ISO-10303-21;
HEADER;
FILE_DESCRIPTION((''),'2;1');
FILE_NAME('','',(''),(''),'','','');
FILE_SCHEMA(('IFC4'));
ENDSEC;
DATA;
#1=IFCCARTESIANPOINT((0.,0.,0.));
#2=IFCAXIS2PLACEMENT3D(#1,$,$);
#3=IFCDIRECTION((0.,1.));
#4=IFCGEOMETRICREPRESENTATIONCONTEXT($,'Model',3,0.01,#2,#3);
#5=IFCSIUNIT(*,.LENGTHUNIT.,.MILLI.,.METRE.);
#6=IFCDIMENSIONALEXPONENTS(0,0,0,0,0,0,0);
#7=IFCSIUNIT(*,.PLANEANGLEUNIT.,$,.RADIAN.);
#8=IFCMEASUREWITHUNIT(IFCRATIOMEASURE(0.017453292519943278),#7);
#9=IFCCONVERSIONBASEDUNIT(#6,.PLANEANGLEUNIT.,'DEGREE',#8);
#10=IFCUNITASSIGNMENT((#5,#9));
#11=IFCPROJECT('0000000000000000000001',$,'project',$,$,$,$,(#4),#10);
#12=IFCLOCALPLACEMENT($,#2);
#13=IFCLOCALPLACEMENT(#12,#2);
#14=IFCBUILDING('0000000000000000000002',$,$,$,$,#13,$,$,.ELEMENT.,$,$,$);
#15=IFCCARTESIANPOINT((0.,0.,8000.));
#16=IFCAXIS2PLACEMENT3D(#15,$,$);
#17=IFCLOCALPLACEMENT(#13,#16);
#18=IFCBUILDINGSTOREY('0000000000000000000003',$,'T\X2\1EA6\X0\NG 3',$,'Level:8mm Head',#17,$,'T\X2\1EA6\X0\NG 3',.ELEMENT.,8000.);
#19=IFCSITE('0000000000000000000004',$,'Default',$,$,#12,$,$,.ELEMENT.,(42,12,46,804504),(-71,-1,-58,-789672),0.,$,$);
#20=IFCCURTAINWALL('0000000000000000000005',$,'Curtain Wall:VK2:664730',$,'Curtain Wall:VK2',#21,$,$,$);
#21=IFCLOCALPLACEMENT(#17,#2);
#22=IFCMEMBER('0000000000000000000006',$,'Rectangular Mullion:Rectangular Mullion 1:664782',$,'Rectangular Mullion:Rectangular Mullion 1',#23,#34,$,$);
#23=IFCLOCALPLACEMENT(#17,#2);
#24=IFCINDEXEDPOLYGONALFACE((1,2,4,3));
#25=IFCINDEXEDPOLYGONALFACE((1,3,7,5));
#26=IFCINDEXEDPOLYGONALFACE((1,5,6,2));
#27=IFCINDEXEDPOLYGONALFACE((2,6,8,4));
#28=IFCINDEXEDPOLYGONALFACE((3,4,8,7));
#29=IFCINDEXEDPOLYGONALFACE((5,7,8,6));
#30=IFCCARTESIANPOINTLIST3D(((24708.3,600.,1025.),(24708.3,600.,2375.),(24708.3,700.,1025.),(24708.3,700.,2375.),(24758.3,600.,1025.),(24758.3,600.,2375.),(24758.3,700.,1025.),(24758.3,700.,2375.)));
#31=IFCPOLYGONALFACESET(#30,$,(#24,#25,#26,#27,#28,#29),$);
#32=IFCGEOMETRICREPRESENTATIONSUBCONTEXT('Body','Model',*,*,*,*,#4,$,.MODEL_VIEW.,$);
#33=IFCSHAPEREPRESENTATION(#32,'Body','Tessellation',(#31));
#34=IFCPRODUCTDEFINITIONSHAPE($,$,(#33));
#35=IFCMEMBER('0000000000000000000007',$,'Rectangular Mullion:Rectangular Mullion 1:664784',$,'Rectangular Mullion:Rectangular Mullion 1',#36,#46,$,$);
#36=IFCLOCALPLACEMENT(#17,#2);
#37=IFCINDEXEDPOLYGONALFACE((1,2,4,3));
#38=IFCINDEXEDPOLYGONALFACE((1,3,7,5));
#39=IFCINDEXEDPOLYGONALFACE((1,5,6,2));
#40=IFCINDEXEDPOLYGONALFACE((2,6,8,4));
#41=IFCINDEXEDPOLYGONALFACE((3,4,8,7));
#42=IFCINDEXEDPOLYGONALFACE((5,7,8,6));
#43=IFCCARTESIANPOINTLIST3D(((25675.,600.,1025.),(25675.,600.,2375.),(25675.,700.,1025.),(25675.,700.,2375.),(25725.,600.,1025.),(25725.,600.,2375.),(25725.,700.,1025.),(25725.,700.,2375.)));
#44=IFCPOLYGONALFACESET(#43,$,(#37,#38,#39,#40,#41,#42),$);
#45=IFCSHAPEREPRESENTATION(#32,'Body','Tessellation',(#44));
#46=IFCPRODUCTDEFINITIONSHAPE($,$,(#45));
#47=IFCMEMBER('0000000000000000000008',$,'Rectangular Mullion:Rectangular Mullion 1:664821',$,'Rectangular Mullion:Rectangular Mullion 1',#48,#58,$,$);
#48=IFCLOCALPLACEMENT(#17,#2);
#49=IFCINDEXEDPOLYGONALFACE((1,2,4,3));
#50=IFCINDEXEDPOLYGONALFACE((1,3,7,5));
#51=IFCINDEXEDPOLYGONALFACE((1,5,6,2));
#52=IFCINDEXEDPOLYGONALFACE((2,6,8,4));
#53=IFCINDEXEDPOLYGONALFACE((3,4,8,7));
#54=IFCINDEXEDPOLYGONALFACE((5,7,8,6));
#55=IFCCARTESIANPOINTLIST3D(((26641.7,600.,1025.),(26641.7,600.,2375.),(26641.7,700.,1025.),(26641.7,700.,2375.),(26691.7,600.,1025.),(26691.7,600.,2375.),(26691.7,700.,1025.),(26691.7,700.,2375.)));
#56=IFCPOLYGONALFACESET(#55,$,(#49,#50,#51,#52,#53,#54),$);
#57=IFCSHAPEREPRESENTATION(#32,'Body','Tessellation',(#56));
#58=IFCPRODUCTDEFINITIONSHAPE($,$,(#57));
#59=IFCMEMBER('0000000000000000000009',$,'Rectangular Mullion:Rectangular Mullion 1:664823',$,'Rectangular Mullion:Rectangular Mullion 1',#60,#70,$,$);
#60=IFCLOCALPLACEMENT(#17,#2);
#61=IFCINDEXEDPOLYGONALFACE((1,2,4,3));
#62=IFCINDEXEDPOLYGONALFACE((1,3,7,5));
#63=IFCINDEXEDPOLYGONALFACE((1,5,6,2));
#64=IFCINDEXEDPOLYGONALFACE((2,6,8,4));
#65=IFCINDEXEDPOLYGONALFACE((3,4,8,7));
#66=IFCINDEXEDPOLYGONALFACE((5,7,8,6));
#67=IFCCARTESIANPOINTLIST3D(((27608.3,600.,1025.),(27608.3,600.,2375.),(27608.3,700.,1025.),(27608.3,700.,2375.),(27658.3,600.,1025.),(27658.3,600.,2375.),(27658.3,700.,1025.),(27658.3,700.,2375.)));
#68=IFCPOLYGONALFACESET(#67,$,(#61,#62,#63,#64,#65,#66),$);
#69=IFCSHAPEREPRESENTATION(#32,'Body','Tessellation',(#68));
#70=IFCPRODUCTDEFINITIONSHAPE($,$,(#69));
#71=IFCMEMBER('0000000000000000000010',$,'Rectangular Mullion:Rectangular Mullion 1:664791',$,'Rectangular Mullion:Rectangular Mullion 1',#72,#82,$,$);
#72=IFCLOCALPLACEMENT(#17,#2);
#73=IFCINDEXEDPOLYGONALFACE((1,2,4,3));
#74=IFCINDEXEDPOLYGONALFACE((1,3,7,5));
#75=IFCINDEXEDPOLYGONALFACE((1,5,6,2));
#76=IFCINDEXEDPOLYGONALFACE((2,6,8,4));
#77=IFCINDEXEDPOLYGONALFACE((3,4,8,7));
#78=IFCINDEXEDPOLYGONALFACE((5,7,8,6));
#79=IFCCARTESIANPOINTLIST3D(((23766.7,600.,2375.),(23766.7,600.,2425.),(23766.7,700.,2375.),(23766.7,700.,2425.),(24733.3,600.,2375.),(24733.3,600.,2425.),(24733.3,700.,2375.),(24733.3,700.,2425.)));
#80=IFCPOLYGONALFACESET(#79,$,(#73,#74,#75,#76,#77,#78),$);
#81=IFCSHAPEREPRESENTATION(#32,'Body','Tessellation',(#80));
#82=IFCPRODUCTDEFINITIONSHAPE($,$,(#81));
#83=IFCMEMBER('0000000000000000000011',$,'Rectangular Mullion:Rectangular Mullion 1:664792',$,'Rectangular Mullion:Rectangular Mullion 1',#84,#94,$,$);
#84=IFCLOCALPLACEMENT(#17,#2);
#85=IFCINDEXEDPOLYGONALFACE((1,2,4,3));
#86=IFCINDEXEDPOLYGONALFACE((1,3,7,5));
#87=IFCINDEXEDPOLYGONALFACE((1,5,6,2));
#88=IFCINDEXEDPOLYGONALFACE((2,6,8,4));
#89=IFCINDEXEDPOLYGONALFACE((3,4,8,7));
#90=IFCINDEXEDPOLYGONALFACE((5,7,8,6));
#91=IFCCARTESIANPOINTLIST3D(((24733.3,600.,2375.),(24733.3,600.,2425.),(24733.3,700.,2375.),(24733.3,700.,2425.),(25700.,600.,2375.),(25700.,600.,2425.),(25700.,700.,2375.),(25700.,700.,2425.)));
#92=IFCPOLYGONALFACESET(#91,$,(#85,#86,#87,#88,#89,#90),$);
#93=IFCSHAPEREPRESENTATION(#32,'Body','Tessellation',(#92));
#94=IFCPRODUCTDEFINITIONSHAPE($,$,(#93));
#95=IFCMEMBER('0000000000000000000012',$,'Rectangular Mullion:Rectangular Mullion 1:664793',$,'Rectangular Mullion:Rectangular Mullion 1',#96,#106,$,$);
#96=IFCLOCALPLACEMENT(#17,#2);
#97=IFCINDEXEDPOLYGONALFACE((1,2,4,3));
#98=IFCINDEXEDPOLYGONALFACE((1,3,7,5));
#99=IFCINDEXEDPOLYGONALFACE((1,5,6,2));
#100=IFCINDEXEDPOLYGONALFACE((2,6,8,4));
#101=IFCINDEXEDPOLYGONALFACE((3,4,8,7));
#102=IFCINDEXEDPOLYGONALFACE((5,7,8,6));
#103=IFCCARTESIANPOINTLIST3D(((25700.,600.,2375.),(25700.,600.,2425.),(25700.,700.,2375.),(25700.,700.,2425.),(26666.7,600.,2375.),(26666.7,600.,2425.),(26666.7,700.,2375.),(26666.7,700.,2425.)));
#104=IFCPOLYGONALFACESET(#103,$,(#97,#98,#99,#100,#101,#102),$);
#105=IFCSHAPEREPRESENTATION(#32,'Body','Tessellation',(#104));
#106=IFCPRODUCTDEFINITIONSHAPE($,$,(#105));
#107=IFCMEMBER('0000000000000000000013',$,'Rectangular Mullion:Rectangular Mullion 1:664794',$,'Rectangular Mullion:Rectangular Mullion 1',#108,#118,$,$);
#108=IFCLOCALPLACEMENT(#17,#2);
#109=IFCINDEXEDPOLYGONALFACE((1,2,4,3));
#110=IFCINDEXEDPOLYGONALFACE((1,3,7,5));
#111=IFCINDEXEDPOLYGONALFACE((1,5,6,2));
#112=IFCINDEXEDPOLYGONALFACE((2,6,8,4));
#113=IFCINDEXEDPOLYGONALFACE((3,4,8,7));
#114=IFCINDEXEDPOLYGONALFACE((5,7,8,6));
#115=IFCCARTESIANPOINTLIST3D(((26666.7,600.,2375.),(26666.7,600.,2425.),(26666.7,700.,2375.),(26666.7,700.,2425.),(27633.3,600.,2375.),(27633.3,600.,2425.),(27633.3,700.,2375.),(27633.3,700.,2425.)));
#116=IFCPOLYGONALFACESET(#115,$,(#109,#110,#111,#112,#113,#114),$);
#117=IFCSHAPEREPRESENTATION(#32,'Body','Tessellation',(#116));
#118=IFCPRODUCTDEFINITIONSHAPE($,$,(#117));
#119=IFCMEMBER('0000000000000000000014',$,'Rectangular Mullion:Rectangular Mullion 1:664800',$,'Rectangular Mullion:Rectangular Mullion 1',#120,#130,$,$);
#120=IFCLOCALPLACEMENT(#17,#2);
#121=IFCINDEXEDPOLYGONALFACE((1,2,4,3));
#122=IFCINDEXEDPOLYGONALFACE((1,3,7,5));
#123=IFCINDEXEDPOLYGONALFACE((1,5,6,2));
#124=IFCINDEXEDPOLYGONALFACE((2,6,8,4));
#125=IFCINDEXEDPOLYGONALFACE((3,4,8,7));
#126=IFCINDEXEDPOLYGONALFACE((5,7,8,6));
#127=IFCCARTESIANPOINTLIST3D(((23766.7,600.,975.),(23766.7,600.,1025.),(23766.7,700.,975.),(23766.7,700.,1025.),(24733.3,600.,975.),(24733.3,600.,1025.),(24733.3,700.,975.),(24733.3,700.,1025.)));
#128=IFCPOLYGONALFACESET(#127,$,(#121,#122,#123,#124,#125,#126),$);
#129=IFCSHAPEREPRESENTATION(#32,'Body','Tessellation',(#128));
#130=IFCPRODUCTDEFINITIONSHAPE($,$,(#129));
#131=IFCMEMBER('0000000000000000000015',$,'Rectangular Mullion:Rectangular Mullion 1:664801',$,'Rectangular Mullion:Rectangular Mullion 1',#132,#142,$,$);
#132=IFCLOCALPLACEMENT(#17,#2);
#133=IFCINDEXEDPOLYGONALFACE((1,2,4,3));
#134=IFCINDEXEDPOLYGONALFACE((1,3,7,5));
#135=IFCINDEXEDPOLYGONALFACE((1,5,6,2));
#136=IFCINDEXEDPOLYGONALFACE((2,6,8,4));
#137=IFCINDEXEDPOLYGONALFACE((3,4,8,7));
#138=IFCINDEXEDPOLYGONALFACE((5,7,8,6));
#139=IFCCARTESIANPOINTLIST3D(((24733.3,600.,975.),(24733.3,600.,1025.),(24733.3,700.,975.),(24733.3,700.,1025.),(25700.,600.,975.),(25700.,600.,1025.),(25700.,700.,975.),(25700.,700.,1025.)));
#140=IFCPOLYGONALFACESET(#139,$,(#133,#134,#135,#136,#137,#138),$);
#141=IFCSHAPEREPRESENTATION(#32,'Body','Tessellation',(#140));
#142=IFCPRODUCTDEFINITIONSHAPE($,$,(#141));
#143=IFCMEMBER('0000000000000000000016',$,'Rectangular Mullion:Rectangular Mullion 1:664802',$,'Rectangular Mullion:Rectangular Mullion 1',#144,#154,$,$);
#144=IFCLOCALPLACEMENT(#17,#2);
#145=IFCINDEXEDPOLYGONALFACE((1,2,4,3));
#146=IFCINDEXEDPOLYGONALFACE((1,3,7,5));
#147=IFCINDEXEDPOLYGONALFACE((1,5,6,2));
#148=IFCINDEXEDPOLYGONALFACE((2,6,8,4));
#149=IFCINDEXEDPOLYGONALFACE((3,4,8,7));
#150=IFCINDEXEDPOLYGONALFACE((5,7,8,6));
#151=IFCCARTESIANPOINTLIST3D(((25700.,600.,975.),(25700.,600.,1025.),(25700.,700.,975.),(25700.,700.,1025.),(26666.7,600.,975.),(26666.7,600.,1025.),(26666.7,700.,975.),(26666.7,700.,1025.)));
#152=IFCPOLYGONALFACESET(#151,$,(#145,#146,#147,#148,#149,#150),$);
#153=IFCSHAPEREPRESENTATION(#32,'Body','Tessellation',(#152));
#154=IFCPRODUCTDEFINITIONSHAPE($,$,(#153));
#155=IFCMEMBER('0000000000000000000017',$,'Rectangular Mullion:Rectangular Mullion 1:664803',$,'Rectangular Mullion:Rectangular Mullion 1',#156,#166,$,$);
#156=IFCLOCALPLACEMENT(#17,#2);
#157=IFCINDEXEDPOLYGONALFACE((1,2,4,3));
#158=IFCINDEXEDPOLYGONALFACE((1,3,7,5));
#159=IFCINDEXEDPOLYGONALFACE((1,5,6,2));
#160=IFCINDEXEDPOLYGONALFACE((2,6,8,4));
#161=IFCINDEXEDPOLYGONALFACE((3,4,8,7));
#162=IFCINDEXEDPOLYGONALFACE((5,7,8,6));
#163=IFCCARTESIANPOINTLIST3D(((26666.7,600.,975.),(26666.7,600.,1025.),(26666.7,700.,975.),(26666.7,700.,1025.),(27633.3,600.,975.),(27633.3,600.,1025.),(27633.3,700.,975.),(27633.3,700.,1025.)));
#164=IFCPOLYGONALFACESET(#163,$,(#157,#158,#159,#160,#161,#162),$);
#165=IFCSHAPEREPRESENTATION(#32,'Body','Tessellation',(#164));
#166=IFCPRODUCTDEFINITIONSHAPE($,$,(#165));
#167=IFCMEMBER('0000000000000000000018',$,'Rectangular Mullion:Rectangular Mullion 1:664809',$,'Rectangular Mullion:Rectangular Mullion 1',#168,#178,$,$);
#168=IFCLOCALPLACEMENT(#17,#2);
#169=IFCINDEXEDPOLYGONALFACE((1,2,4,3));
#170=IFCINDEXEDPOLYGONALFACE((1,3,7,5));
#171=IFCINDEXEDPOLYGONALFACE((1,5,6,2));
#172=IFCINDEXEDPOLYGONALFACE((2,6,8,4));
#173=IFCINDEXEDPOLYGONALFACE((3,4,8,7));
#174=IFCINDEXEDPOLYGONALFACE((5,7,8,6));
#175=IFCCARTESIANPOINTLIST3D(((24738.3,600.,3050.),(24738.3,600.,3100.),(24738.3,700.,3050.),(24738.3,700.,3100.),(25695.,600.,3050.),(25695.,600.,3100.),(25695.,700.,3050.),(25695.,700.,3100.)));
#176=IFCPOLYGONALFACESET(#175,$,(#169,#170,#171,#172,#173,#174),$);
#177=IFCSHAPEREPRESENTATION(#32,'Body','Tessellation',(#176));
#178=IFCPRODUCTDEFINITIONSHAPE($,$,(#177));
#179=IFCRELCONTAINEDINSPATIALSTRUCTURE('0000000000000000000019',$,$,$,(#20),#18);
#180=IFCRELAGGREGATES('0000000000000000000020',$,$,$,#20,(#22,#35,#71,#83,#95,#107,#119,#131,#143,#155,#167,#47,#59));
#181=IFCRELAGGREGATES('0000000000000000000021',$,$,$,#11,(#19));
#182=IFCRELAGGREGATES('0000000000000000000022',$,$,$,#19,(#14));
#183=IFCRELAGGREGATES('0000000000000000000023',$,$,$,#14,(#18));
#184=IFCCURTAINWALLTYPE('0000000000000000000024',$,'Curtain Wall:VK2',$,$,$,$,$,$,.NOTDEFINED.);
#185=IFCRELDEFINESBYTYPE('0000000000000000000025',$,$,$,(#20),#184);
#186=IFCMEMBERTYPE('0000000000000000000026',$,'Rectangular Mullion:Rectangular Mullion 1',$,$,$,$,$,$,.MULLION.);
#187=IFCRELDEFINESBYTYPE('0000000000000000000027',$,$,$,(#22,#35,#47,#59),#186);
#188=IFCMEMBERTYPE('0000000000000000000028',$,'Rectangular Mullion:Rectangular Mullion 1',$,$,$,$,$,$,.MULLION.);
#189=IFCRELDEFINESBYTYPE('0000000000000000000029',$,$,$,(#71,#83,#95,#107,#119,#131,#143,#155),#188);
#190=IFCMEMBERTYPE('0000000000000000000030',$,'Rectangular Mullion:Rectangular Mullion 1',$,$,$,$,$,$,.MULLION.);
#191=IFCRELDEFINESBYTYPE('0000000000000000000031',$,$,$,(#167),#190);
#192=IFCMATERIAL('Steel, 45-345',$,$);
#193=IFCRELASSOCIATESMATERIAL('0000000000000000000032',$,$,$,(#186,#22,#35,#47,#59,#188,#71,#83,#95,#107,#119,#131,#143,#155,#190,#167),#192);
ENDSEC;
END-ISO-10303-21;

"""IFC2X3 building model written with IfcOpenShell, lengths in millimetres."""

from ifc_helpers import new_model, entity, si_unit, converted_unit, direction, frame, origin, origin_2d_with_axis, place, context, subcontext, project, spatial, rectangle, extrude, source, transform, mapped, material, type_object, type_shapes, element, aggregate, save


model = new_model("IFC2X3")

# Units and contexts
model_context = context("Model", 3, precision=0.01, world=origin(), true_north=direction((0.0, 1.0)))
body_context = subcontext(model_context, "Body", "Model", "MODEL_VIEW")
ifc_project = project(units=[si_unit("LENGTHUNIT", "METRE", prefix="MILLI"), converted_unit("PLANEANGLEUNIT", "DEGREE", entity("IfcRatioMeasure", 0.017453292519943278), si_unit("PLANEANGLEUNIT", "RADIAN"), dimensions=[0, 0, 0, 0, 0, 0, 0])], contexts=[model_context])

# Site, building, storey
site_placement = place(None, origin())
site = spatial("IfcSite", under=ifc_project, at=site_placement, Name="Default", CompositionType="ELEMENT", RefLatitude=(42, 12, 46, 804504), RefLongitude=(-71, -1, -58, -789672), RefElevation=0.0)
building_placement = place(site_placement, origin())
building = spatial("IfcBuilding", under=site, at=building_placement, CompositionType="ELEMENT")
storey_placement = place(building_placement, frame((0.0, 0.0, 8000.0)))
storey = spatial("IfcBuildingStorey", under=building, at=storey_placement, Name="TẦNG 3", ObjectType="Level:8mm Head", LongName="TẦNG 3", CompositionType="ELEMENT", Elevation=8000.0)

# Curtain wall, members
curtain_wall_type = type_object("IfcCurtainWallType", Name="Curtain Wall:VK2", PredefinedType="NOTDEFINED")
curtain_wall_1_placement = place(storey_placement, frame((0.0, 0.0, -8000.0)))
curtain_wall_1 = element("IfcCurtainWall", 1, at=curtain_wall_1_placement, inside=storey, type_object=curtain_wall_type, Name="Curtain Wall:VK2:664730", ObjectType="Curtain Wall:VK2")
ifc_material_1 = material(Name="Steel, 45-345")
member_type_1 = type_object("IfcMemberType", Name="Rectangular Mullion:Rectangular Mullion 1", PredefinedType="MULLION", material=ifc_material_1)
shared_shape_1 = source(origin(), body_context, "Body", "SweptSolid", [
    extrude(rectangle(XDim=100.0, YDim=50.0, at=origin_2d_with_axis()), frame((0.0, 50.0, -1350.0), z_axis=(0.0, 0.0, 1.0), x_axis=(0.0, -1.0, 0.0)), (0.0, 0.0, 1.0), 1350.0),
])
type_shapes(member_type_1, [shared_shape_1])
member_1_placement = place(curtain_wall_1_placement, frame((24733.3, 700.0, 9025.0), z_axis=(0.0, 0.0, -1.0), x_axis=(1.0, 0.0, 0.0)))
member_1 = element("IfcMember", 2, at=member_1_placement, type_object=member_type_1, material=ifc_material_1, Name="Rectangular Mullion:Rectangular Mullion 1:664782", ObjectType="Rectangular Mullion:Rectangular Mullion 1", context=body_context, shape_type="MappedRepresentation", body=[
    mapped(shared_shape_1, transform((0.0, 0.0, 0.0), scale=1.0)),
])
member_2_placement = place(curtain_wall_1_placement, frame((25700.0, 700.0, 9025.0), z_axis=(0.0, 0.0, -1.0), x_axis=(1.0, 0.0, 0.0)))
member_2 = element("IfcMember", 3, at=member_2_placement, type_object=member_type_1, material=ifc_material_1, Name="Rectangular Mullion:Rectangular Mullion 1:664784", ObjectType="Rectangular Mullion:Rectangular Mullion 1", context=body_context, shape_type="MappedRepresentation", body=[
    mapped(shared_shape_1, transform((0.0, 0.0, 0.0), scale=1.0)),
])
member_3_placement = place(curtain_wall_1_placement, frame((26666.7, 700.0, 9025.0), z_axis=(0.0, 0.0, -1.0), x_axis=(1.0, 0.0, 0.0)))
member_3 = element("IfcMember", 4, at=member_3_placement, type_object=member_type_1, material=ifc_material_1, Name="Rectangular Mullion:Rectangular Mullion 1:664821", ObjectType="Rectangular Mullion:Rectangular Mullion 1", context=body_context, shape_type="MappedRepresentation", body=[
    mapped(shared_shape_1, transform((0.0, 0.0, 0.0), scale=1.0)),
])
member_4_placement = place(curtain_wall_1_placement, frame((27633.3, 700.0, 9025.0), z_axis=(0.0, 0.0, -1.0), x_axis=(1.0, 0.0, 0.0)))
member_4 = element("IfcMember", 5, at=member_4_placement, type_object=member_type_1, material=ifc_material_1, Name="Rectangular Mullion:Rectangular Mullion 1:664823", ObjectType="Rectangular Mullion:Rectangular Mullion 1", context=body_context, shape_type="MappedRepresentation", body=[
    mapped(shared_shape_1, transform((0.0, 0.0, 0.0), scale=1.0)),
])
member_type_2 = type_object("IfcMemberType", Name="Rectangular Mullion:Rectangular Mullion 1", PredefinedType="MULLION", material=ifc_material_1)
shared_shape_2 = source(origin(), body_context, "Body", "SweptSolid", [
    extrude(rectangle(XDim=100.0, YDim=50.0, at=origin_2d_with_axis()), frame((0.0, 50.0, -966.7), z_axis=(0.0, 0.0, 1.0), x_axis=(0.0, -1.0, 0.0)), (0.0, 0.0, 1.0), 966.7),
])
type_shapes(member_type_2, [shared_shape_2])
member_5_placement = place(curtain_wall_1_placement, frame((24733.3, 700.0, 10400.0), z_axis=(1.0, 0.0, 0.0), x_axis=(0.0, 0.0, 1.0)))
member_5 = element("IfcMember", 6, at=member_5_placement, type_object=member_type_2, material=ifc_material_1, Name="Rectangular Mullion:Rectangular Mullion 1:664791", ObjectType="Rectangular Mullion:Rectangular Mullion 1", context=body_context, shape_type="MappedRepresentation", body=[
    mapped(shared_shape_2, transform((0.0, 0.0, 0.0), scale=1.0)),
])
member_6_placement = place(curtain_wall_1_placement, frame((25700.0, 700.0, 10400.0), z_axis=(1.0, 0.0, 0.0), x_axis=(0.0, 0.0, 1.0)))
member_6 = element("IfcMember", 7, at=member_6_placement, type_object=member_type_2, material=ifc_material_1, Name="Rectangular Mullion:Rectangular Mullion 1:664792", ObjectType="Rectangular Mullion:Rectangular Mullion 1", context=body_context, shape_type="MappedRepresentation", body=[
    mapped(shared_shape_2, transform((0.0, 0.0, 0.0), scale=1.0)),
])
member_7_placement = place(curtain_wall_1_placement, frame((26666.7, 700.0, 10400.0), z_axis=(1.0, 0.0, 0.0), x_axis=(0.0, 0.0, 1.0)))
member_7 = element("IfcMember", 8, at=member_7_placement, type_object=member_type_2, material=ifc_material_1, Name="Rectangular Mullion:Rectangular Mullion 1:664793", ObjectType="Rectangular Mullion:Rectangular Mullion 1", context=body_context, shape_type="MappedRepresentation", body=[
    mapped(shared_shape_2, transform((0.0, 0.0, 0.0), scale=1.0)),
])
member_8_placement = place(curtain_wall_1_placement, frame((27633.3, 700.0, 10400.0), z_axis=(1.0, 0.0, 0.0), x_axis=(0.0, 0.0, 1.0)))
member_8 = element("IfcMember", 9, at=member_8_placement, type_object=member_type_2, material=ifc_material_1, Name="Rectangular Mullion:Rectangular Mullion 1:664794", ObjectType="Rectangular Mullion:Rectangular Mullion 1", context=body_context, shape_type="MappedRepresentation", body=[
    mapped(shared_shape_2, transform((0.0, 0.0, 0.0), scale=1.0)),
])
member_9_placement = place(curtain_wall_1_placement, frame((24733.3, 700.0, 9000.0), z_axis=(1.0, 0.0, 0.0), x_axis=(0.0, 0.0, 1.0)))
member_9 = element("IfcMember", 10, at=member_9_placement, type_object=member_type_2, material=ifc_material_1, Name="Rectangular Mullion:Rectangular Mullion 1:664800", ObjectType="Rectangular Mullion:Rectangular Mullion 1", context=body_context, shape_type="MappedRepresentation", body=[
    mapped(shared_shape_2, transform((0.0, 0.0, 0.0), scale=1.0)),
])
member_10_placement = place(curtain_wall_1_placement, frame((25700.0, 700.0, 9000.0), z_axis=(1.0, 0.0, 0.0), x_axis=(0.0, 0.0, 1.0)))
member_10 = element("IfcMember", 11, at=member_10_placement, type_object=member_type_2, material=ifc_material_1, Name="Rectangular Mullion:Rectangular Mullion 1:664801", ObjectType="Rectangular Mullion:Rectangular Mullion 1", context=body_context, shape_type="MappedRepresentation", body=[
    mapped(shared_shape_2, transform((0.0, 0.0, 0.0), scale=1.0)),
])
member_11_placement = place(curtain_wall_1_placement, frame((26666.7, 700.0, 9000.0), z_axis=(1.0, 0.0, 0.0), x_axis=(0.0, 0.0, 1.0)))
member_11 = element("IfcMember", 12, at=member_11_placement, type_object=member_type_2, material=ifc_material_1, Name="Rectangular Mullion:Rectangular Mullion 1:664802", ObjectType="Rectangular Mullion:Rectangular Mullion 1", context=body_context, shape_type="MappedRepresentation", body=[
    mapped(shared_shape_2, transform((0.0, 0.0, 0.0), scale=1.0)),
])
member_12_placement = place(curtain_wall_1_placement, frame((27633.3, 700.0, 9000.0), z_axis=(1.0, 0.0, 0.0), x_axis=(0.0, 0.0, 1.0)))
member_12 = element("IfcMember", 13, at=member_12_placement, type_object=member_type_2, material=ifc_material_1, Name="Rectangular Mullion:Rectangular Mullion 1:664803", ObjectType="Rectangular Mullion:Rectangular Mullion 1", context=body_context, shape_type="MappedRepresentation", body=[
    mapped(shared_shape_2, transform((0.0, 0.0, 0.0), scale=1.0)),
])
member_type_3 = type_object("IfcMemberType", Name="Rectangular Mullion:Rectangular Mullion 1", PredefinedType="MULLION", material=ifc_material_1)
shared_shape_3 = source(origin(), body_context, "Body", "SweptSolid", [
    extrude(rectangle(XDim=100.0, YDim=50.0, at=origin_2d_with_axis()), frame((-25.0, 50.0, -956.7), z_axis=(0.0, 0.0, 1.0), x_axis=(0.0, -1.0, 0.0)), (0.0, 0.0, 1.0), 956.7),
])
type_shapes(member_type_3, [shared_shape_3])
member_13_placement = place(curtain_wall_1_placement, frame((25695.0, 700.0, 11100.0), z_axis=(1.0, 0.0, 0.0), x_axis=(0.0, 0.0, 1.0)))
member_13 = element("IfcMember", 14, at=member_13_placement, type_object=member_type_3, material=ifc_material_1, Name="Rectangular Mullion:Rectangular Mullion 1:664809", ObjectType="Rectangular Mullion:Rectangular Mullion 1", context=body_context, shape_type="MappedRepresentation", body=[
    mapped(shared_shape_3, transform((0.0, 0.0, 0.0), scale=1.0)),
])
aggregate(curtain_wall_1, [member_1, member_2, member_5, member_6, member_7, member_8, member_9, member_10, member_11, member_12, member_13, member_3, member_4])

save(model, "model.ifc")
